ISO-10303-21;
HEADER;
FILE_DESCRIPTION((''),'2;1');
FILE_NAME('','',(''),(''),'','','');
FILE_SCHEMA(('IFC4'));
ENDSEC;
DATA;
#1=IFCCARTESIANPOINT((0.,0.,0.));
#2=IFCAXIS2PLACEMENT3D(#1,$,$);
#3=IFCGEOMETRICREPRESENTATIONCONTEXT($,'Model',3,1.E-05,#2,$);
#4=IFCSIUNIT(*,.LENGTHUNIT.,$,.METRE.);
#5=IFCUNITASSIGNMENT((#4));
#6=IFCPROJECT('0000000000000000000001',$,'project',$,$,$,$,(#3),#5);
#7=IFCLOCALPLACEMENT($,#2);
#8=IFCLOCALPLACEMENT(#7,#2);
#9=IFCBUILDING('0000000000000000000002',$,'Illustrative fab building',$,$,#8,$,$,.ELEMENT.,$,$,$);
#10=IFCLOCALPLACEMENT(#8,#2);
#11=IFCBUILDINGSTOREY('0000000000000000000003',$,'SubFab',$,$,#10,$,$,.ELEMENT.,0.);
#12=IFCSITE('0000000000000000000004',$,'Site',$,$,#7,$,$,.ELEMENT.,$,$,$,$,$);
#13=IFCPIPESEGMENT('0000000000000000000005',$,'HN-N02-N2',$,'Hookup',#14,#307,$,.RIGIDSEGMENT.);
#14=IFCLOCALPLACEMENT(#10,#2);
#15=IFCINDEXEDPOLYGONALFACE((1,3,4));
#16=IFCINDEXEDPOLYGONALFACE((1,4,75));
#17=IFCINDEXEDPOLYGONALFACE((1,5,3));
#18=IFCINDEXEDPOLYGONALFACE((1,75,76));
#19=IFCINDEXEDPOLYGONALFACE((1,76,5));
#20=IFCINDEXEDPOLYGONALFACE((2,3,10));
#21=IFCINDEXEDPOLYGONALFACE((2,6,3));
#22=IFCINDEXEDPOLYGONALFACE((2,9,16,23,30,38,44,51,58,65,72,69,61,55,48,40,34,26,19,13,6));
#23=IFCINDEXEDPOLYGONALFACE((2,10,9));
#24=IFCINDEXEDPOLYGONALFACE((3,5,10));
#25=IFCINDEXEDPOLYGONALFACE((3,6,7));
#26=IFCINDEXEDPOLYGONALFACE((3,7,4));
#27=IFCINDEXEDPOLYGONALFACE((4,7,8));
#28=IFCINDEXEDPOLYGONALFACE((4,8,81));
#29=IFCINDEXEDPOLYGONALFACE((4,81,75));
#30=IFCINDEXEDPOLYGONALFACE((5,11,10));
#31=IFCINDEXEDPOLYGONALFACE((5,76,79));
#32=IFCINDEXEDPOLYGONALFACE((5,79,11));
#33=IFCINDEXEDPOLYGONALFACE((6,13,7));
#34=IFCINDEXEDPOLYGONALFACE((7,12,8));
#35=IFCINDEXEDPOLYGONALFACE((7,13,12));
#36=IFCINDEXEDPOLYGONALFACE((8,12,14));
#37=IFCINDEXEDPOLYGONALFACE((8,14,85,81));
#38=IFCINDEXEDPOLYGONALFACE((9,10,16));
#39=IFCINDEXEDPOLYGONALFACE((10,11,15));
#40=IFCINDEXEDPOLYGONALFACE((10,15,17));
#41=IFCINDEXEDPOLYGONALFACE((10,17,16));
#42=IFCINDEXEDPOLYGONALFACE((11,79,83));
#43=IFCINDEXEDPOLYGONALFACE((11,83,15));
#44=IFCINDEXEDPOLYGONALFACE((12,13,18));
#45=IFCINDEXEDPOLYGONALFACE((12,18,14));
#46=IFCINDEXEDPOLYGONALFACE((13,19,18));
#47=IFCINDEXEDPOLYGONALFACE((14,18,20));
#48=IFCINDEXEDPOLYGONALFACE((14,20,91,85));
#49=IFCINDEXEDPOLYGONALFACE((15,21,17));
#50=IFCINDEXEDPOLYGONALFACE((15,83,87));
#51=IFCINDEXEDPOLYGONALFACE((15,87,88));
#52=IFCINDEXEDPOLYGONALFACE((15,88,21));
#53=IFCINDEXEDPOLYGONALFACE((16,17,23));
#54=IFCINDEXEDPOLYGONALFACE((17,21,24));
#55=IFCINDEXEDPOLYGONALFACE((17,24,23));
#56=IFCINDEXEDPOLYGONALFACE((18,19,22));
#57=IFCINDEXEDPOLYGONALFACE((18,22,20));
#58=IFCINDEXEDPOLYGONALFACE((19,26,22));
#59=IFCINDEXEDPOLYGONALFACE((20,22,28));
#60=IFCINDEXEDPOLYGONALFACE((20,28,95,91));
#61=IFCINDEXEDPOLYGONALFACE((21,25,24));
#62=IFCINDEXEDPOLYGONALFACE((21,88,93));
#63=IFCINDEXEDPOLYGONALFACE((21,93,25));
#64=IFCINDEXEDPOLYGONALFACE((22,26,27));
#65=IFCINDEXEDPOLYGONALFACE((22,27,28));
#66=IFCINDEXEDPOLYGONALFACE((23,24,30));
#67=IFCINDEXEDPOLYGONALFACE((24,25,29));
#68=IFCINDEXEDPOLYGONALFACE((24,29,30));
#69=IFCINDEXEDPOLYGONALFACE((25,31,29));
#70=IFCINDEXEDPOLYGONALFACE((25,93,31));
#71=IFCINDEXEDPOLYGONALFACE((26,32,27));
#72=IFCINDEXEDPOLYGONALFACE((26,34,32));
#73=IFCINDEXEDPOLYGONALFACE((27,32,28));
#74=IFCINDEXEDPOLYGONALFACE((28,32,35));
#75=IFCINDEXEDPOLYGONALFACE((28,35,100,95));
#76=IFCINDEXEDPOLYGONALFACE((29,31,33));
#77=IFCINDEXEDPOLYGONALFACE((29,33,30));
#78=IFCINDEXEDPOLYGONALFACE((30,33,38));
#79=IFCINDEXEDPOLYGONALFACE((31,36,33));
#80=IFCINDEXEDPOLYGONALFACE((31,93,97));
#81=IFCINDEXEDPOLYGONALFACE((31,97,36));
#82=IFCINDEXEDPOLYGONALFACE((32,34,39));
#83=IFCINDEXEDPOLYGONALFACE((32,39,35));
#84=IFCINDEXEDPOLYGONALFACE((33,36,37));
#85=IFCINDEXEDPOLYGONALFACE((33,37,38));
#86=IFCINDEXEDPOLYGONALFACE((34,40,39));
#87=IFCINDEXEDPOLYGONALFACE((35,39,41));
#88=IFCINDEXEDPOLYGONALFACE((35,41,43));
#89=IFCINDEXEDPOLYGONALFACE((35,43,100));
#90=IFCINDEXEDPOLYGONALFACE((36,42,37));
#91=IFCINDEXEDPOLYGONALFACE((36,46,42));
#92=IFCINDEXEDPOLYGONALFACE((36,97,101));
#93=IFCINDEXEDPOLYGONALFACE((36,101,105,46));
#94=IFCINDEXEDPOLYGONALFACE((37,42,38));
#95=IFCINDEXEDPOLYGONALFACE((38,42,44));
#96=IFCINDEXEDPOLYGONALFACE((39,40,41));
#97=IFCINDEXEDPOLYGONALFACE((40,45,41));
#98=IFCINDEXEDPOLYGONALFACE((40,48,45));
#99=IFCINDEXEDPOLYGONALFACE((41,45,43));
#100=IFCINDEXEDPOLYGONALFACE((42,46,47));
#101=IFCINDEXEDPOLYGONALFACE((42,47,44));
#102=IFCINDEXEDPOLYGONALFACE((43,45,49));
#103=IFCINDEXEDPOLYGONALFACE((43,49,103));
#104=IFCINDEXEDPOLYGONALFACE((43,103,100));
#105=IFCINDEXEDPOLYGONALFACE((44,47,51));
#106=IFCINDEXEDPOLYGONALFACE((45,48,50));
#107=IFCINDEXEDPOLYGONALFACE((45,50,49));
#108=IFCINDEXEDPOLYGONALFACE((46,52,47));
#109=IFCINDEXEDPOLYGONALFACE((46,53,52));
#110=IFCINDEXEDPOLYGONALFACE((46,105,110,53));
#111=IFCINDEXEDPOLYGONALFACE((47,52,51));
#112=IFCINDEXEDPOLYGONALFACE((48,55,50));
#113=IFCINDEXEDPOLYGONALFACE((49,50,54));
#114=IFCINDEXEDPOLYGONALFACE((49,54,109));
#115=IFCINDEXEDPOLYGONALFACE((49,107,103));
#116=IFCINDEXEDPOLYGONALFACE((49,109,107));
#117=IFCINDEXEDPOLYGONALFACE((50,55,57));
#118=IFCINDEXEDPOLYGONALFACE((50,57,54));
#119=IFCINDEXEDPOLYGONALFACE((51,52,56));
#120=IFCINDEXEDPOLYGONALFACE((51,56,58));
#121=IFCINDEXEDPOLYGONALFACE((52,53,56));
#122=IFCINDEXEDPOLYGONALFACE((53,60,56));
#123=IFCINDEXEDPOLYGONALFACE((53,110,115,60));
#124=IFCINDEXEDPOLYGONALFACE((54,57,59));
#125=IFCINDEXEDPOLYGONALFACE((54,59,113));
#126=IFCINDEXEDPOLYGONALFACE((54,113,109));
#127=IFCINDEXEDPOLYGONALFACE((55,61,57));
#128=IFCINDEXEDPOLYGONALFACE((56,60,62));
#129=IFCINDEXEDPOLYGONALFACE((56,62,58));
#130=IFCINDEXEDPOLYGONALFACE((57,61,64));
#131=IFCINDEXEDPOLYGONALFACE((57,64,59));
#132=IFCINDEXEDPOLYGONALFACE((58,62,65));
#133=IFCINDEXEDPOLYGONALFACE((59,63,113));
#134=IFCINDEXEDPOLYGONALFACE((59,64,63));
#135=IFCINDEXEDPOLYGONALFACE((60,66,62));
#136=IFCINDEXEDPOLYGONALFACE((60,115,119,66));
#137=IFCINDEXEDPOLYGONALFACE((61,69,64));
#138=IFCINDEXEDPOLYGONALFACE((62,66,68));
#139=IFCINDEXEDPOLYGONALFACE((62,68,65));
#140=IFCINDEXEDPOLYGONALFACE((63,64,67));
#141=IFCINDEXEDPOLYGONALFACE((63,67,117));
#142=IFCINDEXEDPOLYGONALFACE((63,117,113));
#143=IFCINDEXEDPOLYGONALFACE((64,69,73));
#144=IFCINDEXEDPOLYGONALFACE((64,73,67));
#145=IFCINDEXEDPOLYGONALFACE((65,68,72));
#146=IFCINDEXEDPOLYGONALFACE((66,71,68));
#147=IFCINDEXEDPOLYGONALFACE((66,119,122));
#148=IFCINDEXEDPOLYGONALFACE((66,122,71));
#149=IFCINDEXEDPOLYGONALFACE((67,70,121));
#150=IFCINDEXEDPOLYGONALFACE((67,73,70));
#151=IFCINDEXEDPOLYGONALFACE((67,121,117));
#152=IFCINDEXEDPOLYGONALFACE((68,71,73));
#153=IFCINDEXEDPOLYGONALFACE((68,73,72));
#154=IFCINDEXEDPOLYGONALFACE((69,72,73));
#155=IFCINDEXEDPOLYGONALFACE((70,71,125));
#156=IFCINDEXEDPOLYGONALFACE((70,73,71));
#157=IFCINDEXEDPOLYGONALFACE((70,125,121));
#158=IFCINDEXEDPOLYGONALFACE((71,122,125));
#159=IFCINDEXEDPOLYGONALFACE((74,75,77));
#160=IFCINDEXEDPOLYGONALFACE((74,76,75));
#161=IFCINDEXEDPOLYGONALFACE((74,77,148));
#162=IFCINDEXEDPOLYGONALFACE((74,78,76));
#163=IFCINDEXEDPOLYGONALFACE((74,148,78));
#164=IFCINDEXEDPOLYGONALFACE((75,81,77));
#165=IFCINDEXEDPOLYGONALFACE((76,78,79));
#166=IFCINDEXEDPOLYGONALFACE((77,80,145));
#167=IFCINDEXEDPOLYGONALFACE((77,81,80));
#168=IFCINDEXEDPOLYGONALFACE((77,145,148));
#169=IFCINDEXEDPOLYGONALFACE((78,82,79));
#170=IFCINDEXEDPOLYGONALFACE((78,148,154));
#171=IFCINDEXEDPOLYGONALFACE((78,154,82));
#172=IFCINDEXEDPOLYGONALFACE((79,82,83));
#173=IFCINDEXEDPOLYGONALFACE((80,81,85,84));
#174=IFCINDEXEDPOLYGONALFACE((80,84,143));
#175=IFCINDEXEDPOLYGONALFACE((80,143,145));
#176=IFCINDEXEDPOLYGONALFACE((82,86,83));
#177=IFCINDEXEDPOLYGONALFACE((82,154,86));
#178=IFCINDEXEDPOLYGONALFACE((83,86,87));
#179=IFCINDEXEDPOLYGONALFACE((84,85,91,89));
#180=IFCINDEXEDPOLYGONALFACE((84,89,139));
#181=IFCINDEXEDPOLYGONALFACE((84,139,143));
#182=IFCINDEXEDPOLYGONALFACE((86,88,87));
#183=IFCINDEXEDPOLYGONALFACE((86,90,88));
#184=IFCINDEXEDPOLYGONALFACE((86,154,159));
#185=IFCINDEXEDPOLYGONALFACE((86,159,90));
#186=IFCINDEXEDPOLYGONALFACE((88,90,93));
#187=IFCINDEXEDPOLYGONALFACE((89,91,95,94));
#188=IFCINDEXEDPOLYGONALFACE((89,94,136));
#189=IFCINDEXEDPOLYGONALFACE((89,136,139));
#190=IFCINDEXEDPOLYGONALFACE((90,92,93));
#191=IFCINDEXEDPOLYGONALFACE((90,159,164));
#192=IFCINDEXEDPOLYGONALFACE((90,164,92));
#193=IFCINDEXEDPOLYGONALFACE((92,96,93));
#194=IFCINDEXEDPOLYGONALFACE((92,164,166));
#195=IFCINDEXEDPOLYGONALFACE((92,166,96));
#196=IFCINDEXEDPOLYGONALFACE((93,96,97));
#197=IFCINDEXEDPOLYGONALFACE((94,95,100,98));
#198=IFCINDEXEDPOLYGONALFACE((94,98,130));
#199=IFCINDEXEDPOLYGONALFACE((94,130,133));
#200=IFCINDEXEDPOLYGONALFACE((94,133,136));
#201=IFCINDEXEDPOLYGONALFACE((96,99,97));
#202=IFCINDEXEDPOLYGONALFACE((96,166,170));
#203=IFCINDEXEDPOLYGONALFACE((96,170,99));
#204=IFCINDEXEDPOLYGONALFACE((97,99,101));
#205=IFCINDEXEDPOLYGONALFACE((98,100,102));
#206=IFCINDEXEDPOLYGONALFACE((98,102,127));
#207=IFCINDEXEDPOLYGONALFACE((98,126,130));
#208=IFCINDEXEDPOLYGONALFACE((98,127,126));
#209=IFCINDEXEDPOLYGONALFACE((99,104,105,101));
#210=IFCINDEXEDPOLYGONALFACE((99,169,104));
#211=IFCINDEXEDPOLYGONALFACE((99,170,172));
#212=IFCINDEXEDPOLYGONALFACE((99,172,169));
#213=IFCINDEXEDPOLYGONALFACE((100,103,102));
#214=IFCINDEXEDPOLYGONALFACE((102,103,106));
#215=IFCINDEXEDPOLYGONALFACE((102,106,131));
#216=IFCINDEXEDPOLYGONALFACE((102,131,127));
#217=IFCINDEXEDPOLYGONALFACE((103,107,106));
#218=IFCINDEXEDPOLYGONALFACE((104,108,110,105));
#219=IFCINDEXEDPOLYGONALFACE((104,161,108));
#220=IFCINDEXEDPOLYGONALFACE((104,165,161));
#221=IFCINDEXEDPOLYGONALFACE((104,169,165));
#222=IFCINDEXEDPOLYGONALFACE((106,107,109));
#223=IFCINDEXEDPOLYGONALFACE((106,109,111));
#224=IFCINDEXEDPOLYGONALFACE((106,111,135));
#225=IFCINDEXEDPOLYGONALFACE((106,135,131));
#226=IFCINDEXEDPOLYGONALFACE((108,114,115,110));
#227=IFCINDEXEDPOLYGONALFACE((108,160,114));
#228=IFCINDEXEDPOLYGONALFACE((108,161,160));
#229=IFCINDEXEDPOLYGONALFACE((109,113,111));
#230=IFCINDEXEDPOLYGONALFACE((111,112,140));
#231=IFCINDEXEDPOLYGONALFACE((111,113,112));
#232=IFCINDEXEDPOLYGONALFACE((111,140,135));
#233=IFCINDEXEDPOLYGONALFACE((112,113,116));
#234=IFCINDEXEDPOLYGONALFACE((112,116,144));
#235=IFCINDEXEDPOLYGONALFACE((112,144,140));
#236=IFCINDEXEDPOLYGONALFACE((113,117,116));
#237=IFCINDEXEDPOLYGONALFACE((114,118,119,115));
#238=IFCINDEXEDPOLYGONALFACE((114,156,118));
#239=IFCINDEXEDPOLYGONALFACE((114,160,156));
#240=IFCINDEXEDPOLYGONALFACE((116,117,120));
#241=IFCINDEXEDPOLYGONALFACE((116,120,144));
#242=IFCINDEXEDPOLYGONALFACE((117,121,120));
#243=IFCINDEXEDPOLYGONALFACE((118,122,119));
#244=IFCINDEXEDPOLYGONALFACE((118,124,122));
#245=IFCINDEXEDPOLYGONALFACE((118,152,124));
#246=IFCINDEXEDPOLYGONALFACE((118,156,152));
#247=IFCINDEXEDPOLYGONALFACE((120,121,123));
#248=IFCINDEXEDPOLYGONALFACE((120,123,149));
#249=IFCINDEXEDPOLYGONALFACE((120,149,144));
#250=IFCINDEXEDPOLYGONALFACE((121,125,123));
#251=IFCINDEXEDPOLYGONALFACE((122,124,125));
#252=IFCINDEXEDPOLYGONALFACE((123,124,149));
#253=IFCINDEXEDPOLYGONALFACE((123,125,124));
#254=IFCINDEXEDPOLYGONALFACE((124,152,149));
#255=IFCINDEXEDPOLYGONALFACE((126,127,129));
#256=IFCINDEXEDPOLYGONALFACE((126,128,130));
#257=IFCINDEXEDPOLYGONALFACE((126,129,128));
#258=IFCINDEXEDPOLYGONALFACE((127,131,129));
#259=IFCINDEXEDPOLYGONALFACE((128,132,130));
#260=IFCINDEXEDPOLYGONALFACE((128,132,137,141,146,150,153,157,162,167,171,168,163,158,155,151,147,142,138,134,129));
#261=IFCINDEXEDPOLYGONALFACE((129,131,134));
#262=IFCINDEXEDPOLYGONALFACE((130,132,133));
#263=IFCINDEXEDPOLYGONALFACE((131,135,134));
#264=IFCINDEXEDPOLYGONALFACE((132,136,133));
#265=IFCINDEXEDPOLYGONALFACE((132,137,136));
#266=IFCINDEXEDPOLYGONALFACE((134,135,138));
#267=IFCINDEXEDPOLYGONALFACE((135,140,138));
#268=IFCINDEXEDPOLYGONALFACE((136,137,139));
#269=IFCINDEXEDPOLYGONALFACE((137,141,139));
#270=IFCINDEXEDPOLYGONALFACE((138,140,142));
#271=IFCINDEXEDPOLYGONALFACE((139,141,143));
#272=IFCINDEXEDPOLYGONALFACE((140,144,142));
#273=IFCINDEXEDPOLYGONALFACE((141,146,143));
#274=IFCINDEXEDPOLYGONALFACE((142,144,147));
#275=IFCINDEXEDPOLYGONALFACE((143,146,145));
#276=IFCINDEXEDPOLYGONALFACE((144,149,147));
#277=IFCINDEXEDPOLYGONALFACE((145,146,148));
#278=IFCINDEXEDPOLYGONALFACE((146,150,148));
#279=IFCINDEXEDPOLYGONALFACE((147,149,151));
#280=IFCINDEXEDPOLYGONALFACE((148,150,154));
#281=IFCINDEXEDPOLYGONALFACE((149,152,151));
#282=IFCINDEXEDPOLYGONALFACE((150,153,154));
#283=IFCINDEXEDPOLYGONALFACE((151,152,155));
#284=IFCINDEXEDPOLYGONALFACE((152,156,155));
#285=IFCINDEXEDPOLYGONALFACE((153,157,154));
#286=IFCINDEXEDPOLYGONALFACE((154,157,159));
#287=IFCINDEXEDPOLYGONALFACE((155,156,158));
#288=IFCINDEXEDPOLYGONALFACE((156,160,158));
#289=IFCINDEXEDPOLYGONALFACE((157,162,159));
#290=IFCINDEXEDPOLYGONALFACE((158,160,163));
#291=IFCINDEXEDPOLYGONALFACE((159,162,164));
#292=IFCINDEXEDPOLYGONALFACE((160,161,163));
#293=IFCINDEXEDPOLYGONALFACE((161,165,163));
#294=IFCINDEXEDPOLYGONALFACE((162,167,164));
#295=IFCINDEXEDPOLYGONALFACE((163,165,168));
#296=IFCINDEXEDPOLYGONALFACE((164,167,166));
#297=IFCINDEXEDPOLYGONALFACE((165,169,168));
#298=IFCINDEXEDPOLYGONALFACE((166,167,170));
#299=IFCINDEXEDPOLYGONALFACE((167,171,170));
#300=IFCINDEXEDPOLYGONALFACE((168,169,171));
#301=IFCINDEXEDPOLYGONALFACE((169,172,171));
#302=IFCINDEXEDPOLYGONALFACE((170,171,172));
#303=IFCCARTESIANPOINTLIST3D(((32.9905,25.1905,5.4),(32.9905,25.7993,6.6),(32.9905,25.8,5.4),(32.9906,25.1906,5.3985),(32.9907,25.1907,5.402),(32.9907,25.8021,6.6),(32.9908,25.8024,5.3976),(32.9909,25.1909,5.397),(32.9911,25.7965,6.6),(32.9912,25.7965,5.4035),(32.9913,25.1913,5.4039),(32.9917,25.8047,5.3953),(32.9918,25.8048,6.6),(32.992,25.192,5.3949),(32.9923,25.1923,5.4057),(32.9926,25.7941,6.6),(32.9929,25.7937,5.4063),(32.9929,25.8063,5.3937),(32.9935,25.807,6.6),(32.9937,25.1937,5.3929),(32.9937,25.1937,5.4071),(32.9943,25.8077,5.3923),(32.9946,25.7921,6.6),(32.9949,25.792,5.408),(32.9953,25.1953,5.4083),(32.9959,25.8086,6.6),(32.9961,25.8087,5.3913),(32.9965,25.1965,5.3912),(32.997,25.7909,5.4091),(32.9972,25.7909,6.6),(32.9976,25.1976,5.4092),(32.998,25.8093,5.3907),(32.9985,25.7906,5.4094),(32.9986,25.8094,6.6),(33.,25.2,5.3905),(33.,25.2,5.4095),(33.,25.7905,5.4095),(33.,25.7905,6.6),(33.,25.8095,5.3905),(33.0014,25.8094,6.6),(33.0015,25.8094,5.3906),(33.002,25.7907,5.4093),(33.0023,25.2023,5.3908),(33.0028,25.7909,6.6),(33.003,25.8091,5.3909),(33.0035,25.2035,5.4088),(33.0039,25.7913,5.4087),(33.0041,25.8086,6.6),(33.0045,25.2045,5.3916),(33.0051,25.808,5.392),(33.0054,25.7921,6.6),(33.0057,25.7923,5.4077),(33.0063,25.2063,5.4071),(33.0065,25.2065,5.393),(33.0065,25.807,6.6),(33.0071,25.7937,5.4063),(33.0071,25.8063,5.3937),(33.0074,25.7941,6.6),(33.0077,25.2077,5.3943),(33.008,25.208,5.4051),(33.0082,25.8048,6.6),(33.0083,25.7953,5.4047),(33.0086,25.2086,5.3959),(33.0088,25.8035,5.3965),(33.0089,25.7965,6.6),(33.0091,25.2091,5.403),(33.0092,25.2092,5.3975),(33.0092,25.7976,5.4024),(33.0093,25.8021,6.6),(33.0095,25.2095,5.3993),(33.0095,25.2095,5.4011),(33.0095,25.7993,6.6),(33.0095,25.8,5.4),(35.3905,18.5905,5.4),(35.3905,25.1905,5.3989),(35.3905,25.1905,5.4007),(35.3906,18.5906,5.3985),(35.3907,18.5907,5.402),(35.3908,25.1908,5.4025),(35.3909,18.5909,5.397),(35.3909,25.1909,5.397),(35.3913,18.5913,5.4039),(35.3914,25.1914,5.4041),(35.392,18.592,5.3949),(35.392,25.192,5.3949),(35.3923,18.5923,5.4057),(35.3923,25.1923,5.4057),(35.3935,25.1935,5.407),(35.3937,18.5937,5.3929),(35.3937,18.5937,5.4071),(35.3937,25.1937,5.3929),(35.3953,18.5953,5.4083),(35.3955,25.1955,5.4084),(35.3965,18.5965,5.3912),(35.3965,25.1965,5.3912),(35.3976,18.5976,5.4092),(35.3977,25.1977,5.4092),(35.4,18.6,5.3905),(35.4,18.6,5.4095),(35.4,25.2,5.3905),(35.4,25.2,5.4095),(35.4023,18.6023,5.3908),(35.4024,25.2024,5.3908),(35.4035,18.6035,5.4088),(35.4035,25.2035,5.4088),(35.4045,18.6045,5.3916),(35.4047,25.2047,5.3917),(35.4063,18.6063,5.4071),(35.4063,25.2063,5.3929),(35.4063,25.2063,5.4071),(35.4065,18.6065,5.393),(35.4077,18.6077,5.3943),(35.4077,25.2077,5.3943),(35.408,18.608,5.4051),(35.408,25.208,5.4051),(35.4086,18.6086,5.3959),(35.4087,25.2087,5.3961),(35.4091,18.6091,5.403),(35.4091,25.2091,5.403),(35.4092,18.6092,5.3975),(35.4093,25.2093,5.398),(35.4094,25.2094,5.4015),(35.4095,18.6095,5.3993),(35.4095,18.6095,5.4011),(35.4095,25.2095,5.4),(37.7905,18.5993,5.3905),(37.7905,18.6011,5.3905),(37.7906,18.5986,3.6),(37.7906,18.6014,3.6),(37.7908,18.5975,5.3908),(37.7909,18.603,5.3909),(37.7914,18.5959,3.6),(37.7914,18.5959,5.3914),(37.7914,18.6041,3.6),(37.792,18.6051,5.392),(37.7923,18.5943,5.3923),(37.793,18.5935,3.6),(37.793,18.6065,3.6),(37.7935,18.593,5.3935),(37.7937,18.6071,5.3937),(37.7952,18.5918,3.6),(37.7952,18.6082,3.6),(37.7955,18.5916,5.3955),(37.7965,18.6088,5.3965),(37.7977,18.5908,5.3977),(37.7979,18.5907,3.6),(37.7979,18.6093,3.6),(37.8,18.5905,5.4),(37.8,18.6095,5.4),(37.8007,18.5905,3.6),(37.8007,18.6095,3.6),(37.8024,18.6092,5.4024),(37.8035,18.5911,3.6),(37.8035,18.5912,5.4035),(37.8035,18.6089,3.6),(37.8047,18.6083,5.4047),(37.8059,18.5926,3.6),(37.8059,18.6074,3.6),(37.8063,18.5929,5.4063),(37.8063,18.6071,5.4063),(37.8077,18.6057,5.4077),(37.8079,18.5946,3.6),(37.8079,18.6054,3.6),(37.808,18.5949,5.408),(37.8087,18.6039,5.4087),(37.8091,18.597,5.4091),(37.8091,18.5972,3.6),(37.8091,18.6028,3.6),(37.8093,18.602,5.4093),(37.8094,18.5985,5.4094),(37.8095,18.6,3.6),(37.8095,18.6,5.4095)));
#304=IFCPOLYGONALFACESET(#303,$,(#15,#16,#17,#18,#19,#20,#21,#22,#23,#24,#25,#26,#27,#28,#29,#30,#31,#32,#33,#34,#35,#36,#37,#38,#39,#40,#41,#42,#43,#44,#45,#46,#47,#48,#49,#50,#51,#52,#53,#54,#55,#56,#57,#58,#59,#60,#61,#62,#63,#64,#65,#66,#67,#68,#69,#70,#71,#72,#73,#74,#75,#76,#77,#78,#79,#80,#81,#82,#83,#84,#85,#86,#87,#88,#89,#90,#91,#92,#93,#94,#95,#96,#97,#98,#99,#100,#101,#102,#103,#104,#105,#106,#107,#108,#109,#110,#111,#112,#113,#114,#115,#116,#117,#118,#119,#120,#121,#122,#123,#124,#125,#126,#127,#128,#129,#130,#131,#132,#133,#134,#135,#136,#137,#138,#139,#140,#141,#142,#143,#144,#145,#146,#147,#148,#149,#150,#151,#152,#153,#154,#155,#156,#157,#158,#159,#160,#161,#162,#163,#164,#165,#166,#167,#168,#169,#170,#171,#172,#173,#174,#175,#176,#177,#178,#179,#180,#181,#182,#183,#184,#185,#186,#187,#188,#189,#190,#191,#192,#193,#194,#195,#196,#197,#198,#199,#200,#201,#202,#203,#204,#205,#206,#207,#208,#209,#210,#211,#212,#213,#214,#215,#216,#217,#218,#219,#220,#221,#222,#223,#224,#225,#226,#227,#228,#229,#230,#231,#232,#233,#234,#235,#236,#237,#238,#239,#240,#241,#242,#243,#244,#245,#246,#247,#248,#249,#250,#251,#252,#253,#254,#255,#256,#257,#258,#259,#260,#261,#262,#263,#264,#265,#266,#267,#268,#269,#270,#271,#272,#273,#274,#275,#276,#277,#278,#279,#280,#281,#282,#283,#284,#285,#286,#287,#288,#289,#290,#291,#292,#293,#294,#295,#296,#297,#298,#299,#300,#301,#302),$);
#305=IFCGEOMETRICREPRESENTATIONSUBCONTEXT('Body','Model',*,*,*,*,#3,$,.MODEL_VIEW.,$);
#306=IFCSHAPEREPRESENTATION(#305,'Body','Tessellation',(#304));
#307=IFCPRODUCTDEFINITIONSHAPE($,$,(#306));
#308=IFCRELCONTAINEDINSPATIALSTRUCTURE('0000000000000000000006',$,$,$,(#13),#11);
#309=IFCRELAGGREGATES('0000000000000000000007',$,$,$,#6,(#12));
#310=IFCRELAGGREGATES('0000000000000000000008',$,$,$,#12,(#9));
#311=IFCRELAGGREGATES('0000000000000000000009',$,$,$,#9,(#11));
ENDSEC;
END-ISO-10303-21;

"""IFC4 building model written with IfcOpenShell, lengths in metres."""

from ifc_helpers import new_model, entity, si_unit, origin, place, context, subcontext, project, spatial, element, save


model = new_model("IFC4")

# Units and contexts
model_context = context("Model", 3, precision=1e-05, world=origin())
body_context = subcontext(model_context, "Body", "Model", "MODEL_VIEW")
ifc_project = project(units=[si_unit("LENGTHUNIT", "METRE")], contexts=[model_context])

# Site, building, storey
site_placement = place(None, origin())
site = spatial("IfcSite", under=ifc_project, at=site_placement, Name="Site", CompositionType="ELEMENT")
building_placement = place(site_placement, origin())
building = spatial("IfcBuilding", under=site, at=building_placement, Name="Illustrative fab building", CompositionType="ELEMENT")
storey_placement = place(building_placement, origin())
storey = spatial("IfcBuildingStorey", under=building, at=storey_placement, Name="SubFab", CompositionType="ELEMENT", Elevation=0.0)

# Pipe segment
pipe_segment_1_placement = place(storey_placement, origin())
element("IfcPipeSegment", 1, at=pipe_segment_1_placement, inside=storey, Name="HN-N02-N2", ObjectType="Hookup", PredefinedType="RIGIDSEGMENT", context=body_context, shape_type="AdvancedSweptSolid", body=[
    entity("IfcSweptDiskSolid", entity("IfcPolyline", [entity("IfcCartesianPoint", [37.8, 18.6, 3.6]), entity("IfcCartesianPoint", [37.8, 18.6, 5.4]), entity("IfcCartesianPoint", [35.4, 18.6, 5.4]), entity("IfcCartesianPoint", [35.4, 25.2, 5.4]), entity("IfcCartesianPoint", [33.0, 25.2, 5.4]), entity("IfcCartesianPoint", [33.0, 25.8, 5.4]), entity("IfcCartesianPoint", [33.0, 25.8, 6.6])]), 0.0095),
])

save(model, "model.ifc")
